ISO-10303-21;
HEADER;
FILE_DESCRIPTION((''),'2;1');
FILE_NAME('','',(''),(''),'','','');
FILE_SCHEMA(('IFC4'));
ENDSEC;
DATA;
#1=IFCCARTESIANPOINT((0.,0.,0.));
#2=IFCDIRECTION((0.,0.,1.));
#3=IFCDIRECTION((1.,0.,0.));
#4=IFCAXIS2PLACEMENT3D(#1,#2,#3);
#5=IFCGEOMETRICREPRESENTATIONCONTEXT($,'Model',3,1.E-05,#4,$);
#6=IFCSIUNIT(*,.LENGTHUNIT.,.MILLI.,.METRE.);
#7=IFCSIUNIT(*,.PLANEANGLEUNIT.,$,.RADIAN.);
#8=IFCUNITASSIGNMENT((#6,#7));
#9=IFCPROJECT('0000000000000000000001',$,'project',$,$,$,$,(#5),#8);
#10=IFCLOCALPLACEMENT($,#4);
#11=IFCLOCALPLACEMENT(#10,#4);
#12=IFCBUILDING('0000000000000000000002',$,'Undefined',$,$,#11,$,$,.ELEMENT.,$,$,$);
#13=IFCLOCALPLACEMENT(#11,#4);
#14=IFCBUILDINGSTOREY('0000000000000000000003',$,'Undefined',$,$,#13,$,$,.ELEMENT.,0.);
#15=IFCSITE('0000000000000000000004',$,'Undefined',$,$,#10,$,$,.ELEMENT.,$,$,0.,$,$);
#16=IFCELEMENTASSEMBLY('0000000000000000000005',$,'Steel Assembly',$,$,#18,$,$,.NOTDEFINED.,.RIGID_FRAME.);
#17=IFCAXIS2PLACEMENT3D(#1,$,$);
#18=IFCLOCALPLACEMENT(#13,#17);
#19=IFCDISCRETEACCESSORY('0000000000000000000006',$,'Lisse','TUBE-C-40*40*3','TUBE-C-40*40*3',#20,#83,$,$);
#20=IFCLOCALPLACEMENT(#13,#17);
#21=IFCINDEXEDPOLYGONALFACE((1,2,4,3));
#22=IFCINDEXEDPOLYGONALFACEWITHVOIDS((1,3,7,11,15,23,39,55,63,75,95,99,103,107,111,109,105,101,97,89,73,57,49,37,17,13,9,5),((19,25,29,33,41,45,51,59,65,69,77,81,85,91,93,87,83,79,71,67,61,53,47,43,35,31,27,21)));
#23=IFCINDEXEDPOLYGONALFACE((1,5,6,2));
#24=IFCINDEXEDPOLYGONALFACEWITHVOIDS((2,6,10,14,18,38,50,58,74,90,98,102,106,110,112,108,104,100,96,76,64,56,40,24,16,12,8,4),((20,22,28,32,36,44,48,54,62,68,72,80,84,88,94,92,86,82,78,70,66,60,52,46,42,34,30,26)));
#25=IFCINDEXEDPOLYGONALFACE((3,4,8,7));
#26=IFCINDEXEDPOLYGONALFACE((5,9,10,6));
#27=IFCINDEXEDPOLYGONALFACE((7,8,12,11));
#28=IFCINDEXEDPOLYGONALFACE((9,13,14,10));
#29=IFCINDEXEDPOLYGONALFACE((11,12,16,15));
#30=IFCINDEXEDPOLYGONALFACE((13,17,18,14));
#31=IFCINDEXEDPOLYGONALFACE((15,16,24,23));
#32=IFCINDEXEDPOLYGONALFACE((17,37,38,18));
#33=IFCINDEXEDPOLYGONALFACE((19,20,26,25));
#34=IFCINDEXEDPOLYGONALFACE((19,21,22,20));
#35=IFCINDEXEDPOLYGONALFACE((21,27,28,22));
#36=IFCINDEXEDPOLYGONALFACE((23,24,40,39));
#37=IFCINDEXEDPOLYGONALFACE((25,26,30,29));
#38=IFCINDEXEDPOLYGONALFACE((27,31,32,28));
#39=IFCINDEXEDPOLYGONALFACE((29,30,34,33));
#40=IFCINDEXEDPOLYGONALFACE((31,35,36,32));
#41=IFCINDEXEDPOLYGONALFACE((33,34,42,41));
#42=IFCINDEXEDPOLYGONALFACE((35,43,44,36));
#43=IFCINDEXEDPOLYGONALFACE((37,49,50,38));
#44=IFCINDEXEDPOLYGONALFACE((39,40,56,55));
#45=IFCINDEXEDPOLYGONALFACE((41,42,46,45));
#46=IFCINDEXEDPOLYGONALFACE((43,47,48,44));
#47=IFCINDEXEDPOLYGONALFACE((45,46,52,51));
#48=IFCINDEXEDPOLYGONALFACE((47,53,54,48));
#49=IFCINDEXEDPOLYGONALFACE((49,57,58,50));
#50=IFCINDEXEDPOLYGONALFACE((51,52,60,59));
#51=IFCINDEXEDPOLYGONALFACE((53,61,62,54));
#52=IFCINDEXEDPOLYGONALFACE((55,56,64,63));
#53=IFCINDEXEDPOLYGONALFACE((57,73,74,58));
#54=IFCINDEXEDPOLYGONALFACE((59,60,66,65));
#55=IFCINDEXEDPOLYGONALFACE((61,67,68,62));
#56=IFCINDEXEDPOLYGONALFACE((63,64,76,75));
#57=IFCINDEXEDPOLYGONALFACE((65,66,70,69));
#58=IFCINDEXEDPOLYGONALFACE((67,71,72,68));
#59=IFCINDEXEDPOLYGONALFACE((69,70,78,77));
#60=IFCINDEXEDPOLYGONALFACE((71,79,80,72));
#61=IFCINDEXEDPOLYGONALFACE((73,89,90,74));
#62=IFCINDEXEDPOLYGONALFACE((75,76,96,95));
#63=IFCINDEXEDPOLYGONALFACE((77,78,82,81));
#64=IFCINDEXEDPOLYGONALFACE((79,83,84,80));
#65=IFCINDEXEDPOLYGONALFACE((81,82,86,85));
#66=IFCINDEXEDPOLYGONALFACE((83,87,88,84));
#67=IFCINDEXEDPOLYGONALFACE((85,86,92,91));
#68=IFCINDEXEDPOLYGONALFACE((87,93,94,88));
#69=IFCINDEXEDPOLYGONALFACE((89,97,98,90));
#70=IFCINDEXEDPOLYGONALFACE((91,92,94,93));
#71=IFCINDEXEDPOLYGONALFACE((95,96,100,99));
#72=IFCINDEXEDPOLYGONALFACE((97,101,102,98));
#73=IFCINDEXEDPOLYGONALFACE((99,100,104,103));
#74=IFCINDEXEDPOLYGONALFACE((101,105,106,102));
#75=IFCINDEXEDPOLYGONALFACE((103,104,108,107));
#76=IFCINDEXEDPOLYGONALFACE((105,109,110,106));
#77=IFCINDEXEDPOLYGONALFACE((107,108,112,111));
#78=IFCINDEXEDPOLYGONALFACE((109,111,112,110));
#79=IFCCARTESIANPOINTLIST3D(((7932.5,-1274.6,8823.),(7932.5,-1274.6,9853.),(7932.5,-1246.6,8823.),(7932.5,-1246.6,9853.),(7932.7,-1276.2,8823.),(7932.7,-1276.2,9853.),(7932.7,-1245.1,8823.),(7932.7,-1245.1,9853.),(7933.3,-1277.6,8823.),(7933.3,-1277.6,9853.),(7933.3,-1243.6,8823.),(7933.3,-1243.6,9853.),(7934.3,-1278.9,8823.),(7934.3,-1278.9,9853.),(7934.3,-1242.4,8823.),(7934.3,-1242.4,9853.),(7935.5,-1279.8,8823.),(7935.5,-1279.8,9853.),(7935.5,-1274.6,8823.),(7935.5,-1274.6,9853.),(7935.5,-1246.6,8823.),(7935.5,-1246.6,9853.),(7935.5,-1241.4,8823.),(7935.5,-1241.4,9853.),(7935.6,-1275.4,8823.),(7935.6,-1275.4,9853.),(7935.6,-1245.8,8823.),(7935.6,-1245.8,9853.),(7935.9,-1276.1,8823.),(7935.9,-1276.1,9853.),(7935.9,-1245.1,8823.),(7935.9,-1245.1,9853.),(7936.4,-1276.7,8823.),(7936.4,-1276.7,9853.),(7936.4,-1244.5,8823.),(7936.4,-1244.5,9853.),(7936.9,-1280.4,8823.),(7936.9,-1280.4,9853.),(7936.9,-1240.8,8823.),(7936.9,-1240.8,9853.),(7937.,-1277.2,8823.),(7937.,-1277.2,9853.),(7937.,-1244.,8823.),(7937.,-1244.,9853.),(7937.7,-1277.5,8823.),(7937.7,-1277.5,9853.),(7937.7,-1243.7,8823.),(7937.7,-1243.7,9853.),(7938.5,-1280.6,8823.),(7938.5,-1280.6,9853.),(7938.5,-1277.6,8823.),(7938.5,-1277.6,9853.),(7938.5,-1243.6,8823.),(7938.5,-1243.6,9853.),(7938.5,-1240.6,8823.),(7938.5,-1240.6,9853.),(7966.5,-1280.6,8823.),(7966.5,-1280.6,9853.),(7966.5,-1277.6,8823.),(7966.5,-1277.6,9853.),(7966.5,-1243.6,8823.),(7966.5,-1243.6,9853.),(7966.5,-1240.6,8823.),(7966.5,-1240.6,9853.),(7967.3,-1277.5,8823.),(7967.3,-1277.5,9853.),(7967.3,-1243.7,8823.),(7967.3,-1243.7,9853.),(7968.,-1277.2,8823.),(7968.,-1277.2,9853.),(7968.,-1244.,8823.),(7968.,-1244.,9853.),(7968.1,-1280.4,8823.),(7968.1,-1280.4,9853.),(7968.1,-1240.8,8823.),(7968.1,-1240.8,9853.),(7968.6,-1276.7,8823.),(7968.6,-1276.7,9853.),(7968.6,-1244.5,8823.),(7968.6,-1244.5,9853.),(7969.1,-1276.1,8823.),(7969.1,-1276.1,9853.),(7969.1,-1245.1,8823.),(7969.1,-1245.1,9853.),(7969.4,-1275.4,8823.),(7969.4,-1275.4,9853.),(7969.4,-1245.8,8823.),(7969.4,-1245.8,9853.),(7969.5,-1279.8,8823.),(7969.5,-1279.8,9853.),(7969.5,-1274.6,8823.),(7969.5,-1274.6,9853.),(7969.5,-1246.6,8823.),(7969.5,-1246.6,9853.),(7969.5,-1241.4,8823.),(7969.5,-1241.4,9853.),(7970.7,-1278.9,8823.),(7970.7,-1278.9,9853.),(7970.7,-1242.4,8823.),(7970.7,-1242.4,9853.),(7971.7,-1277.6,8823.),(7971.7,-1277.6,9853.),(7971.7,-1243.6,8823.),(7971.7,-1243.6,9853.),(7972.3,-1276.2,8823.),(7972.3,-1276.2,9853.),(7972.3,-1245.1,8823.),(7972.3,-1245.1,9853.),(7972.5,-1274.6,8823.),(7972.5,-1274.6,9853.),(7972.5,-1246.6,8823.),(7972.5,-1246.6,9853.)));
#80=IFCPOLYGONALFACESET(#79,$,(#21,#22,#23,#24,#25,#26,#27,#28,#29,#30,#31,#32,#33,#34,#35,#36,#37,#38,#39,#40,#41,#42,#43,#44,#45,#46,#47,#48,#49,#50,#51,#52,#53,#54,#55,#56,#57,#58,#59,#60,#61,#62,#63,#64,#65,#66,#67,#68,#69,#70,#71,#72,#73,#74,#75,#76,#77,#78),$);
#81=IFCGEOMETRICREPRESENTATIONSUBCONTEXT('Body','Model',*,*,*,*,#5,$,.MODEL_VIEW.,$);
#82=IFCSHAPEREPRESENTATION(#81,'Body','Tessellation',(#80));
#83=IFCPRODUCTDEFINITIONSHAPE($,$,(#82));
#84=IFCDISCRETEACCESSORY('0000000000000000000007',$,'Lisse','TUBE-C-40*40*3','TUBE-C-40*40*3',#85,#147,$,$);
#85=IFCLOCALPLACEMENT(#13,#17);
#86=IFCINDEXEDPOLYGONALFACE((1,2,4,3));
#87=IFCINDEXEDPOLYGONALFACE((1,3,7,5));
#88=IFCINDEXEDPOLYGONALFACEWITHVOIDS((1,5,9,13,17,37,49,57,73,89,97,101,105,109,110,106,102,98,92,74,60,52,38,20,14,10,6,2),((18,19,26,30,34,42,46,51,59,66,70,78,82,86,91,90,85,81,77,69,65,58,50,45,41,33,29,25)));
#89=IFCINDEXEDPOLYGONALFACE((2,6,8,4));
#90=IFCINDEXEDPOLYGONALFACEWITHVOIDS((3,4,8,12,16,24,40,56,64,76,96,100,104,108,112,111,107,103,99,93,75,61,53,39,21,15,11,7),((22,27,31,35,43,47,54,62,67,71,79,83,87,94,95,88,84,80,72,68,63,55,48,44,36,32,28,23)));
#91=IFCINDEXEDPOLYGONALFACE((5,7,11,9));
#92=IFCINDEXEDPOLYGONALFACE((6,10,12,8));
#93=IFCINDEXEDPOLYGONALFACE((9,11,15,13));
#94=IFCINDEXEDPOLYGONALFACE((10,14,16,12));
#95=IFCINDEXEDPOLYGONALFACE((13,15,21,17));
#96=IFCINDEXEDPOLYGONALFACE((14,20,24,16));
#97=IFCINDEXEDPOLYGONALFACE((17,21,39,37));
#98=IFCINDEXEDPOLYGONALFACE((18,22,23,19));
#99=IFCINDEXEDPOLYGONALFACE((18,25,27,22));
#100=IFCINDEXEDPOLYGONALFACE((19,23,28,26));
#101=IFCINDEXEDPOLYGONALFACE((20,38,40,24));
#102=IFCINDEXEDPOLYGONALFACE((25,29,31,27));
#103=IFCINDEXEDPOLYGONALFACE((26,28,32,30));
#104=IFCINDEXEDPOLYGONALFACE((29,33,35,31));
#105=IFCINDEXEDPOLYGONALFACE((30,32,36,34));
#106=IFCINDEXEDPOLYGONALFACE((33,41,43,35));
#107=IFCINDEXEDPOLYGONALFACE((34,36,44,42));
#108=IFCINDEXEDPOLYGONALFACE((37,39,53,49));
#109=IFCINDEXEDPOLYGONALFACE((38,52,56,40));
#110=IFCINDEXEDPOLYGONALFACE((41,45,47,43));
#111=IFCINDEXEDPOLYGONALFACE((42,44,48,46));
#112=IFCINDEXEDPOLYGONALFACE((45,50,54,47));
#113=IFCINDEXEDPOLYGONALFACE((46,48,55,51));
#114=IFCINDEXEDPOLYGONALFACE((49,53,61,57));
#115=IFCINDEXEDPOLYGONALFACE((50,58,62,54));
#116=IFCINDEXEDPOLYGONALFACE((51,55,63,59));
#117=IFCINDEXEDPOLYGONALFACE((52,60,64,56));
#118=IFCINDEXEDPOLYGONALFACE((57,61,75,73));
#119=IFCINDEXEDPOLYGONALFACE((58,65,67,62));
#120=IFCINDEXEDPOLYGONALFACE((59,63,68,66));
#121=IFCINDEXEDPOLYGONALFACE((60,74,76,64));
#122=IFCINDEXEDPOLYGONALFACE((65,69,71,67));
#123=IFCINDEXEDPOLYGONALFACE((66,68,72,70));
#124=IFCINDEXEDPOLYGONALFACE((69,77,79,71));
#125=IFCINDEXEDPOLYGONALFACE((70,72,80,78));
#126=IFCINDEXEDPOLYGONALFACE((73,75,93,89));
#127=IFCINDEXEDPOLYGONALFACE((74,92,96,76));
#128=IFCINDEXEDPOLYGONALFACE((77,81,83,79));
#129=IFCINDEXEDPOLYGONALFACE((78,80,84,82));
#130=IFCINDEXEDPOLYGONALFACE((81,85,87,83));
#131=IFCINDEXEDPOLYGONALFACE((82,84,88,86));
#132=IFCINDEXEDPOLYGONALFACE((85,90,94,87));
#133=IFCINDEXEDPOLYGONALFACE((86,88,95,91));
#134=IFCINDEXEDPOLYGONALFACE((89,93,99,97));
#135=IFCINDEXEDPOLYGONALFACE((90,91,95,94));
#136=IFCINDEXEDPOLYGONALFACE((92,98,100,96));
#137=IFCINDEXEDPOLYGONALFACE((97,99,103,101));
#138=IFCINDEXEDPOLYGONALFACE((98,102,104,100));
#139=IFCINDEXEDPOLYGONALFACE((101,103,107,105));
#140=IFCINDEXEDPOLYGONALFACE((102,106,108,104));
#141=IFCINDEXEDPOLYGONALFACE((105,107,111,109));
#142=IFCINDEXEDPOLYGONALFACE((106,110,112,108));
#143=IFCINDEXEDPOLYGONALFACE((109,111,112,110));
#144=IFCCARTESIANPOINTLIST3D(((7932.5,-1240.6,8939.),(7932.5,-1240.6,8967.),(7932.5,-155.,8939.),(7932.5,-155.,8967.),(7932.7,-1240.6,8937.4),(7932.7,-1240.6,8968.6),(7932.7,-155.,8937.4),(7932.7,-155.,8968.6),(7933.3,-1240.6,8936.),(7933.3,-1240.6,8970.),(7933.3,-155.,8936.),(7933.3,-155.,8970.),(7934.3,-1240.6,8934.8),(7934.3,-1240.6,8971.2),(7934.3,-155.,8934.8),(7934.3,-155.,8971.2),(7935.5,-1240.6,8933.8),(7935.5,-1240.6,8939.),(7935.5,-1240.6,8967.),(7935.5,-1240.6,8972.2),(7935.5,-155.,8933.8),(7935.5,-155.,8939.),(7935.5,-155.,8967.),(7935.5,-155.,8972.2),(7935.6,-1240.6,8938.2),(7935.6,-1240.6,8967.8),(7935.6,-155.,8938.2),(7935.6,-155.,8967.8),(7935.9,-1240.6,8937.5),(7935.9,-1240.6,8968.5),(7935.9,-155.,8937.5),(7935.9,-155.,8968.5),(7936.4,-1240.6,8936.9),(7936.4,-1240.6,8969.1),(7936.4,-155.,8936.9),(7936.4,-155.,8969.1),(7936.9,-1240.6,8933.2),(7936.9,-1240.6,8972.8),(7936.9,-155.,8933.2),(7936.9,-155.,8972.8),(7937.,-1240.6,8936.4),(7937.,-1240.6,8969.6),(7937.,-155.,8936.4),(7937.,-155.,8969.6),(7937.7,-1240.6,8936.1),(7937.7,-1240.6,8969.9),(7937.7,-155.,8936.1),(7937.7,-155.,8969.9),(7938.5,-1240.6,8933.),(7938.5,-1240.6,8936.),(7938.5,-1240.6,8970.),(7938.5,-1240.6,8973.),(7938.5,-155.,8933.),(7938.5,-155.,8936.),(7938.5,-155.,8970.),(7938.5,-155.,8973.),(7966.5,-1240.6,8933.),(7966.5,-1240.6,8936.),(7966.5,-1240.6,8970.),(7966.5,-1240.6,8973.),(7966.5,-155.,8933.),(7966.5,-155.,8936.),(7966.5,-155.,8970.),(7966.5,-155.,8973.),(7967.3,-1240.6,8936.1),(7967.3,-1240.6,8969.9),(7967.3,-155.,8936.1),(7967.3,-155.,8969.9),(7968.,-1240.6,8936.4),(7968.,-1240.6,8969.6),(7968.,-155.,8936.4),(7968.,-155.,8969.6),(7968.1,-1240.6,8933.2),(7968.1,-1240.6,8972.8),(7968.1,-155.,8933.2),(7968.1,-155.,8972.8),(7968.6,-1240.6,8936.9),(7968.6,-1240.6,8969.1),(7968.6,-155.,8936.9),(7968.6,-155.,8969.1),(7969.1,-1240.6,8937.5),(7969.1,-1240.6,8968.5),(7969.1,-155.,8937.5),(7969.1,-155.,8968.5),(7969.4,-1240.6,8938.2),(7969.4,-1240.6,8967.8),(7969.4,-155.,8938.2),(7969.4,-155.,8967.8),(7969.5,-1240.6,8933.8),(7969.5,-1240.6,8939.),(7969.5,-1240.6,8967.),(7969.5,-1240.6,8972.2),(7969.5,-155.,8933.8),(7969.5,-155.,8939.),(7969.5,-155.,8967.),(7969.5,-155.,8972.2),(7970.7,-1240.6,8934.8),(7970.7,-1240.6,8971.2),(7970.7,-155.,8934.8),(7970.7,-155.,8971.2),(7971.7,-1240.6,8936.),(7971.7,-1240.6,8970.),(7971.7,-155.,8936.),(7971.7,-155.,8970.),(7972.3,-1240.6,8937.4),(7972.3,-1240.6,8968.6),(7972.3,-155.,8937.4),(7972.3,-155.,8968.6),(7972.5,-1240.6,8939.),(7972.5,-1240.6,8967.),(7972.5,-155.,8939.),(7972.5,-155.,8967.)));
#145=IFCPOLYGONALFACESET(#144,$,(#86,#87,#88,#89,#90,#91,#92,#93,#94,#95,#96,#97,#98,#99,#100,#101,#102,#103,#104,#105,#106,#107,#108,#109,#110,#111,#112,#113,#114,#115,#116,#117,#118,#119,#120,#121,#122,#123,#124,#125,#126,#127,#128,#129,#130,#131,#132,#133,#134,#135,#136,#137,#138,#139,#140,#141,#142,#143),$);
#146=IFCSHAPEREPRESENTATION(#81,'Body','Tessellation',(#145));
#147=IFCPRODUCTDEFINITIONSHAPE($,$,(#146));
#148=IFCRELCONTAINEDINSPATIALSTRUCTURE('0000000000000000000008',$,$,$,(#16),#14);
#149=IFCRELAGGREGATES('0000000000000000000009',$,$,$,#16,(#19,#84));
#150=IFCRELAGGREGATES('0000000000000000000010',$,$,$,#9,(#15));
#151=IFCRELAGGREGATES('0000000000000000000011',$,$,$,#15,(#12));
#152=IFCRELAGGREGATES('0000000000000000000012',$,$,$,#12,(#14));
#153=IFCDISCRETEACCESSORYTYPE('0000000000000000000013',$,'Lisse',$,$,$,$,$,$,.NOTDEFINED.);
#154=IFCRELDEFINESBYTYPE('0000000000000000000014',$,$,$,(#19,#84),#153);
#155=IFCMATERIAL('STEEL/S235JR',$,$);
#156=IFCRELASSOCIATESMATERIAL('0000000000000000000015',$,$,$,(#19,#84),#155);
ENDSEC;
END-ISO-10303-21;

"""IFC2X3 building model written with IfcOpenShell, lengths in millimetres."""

from ifc_helpers import new_model, si_unit, frame, origin_with_axes, origin_2d_with_axis, place, context, subcontext, project, spatial, hollow_rectangle, extrude, material, type_object, element, aggregate, save


model = new_model("IFC2X3")

# Units and contexts
model_context = context("Model", 3, precision=1e-05, world=origin_with_axes())
body_context = subcontext(model_context, "Body", "Model", "MODEL_VIEW")
ifc_project = project(units=[si_unit("LENGTHUNIT", "METRE", prefix="MILLI"), si_unit("PLANEANGLEUNIT", "RADIAN")], contexts=[model_context])

# Site, building, storey
site_placement = place(None, origin_with_axes())
site = spatial("IfcSite", under=ifc_project, at=site_placement, Name="Undefined", CompositionType="ELEMENT", RefElevation=0.0)
building_placement = place(site_placement, origin_with_axes())
building = spatial("IfcBuilding", under=site, at=building_placement, Name="Undefined", CompositionType="ELEMENT")
storey_placement = place(building_placement, origin_with_axes())
storey = spatial("IfcBuildingStorey", under=building, at=storey_placement, Name="Undefined", CompositionType="ELEMENT", Elevation=0.0)

# Element assembly
assembly_1_placement = place(storey_placement, origin_with_axes())
assembly_1 = element("IfcElementAssembly", 1, at=assembly_1_placement, inside=storey, Name="Steel Assembly", AssemblyPlace="NOTDEFINED", PredefinedType="RIGID_FRAME")
ifc_material_1 = material(Name="STEEL/S235JR")

# Discrete accessories
discrete_accessory_type_1 = type_object("IfcDiscreteAccessoryType", Name="Lisse")
discrete_accessory_1_placement = place(assembly_1_placement, frame((7952.5, -1260.6, 9853.0), z_axis=(0.0, 1.0, 0.0), x_axis=(0.0, 0.0, -1.0)))
discrete_accessory_1 = element("IfcDiscreteAccessory", 2, at=discrete_accessory_1_placement, type_object=discrete_accessory_type_1, material=ifc_material_1, Name="Lisse", Description="TUBE-C-40*40*3", ObjectType="TUBE-C-40*40*3", context=body_context, shape_type="SweptSolid", body=[
    extrude(hollow_rectangle(XDim=40.0, YDim=40.0, WallThickness=3.0, InnerFilletRadius=3.0, OuterFilletRadius=6.0, at=origin_2d_with_axis()), frame((1030.0, 0.0, 0.0), z_axis=(-1.0, 0.0, 0.0), x_axis=(0.0, -1.0, 0.0)), (0.0, 0.0, 1.0), 1030.0),
])
discrete_accessory_2_placement = place(assembly_1_placement, frame((7952.5, -155.0, 8953.0), z_axis=(-1.0, 0.0, 0.0), x_axis=(0.0, -1.0, 0.0)))
discrete_accessory_2 = element("IfcDiscreteAccessory", 3, at=discrete_accessory_2_placement, type_object=discrete_accessory_type_1, material=ifc_material_1, Name="Lisse", Description="TUBE-C-40*40*3", ObjectType="TUBE-C-40*40*3", context=body_context, shape_type="SweptSolid", body=[
    extrude(hollow_rectangle(XDim=40.0, YDim=40.0, WallThickness=3.0, InnerFilletRadius=3.0, OuterFilletRadius=6.0, at=origin_2d_with_axis()), frame((1085.6, 0.0, 0.0), z_axis=(-1.0, 0.0, 0.0), x_axis=(0.0, -1.0, 0.0)), (0.0, 0.0, 1.0), 1085.6),
])
aggregate(assembly_1, [discrete_accessory_1, discrete_accessory_2])

save(model, "model.ifc")
